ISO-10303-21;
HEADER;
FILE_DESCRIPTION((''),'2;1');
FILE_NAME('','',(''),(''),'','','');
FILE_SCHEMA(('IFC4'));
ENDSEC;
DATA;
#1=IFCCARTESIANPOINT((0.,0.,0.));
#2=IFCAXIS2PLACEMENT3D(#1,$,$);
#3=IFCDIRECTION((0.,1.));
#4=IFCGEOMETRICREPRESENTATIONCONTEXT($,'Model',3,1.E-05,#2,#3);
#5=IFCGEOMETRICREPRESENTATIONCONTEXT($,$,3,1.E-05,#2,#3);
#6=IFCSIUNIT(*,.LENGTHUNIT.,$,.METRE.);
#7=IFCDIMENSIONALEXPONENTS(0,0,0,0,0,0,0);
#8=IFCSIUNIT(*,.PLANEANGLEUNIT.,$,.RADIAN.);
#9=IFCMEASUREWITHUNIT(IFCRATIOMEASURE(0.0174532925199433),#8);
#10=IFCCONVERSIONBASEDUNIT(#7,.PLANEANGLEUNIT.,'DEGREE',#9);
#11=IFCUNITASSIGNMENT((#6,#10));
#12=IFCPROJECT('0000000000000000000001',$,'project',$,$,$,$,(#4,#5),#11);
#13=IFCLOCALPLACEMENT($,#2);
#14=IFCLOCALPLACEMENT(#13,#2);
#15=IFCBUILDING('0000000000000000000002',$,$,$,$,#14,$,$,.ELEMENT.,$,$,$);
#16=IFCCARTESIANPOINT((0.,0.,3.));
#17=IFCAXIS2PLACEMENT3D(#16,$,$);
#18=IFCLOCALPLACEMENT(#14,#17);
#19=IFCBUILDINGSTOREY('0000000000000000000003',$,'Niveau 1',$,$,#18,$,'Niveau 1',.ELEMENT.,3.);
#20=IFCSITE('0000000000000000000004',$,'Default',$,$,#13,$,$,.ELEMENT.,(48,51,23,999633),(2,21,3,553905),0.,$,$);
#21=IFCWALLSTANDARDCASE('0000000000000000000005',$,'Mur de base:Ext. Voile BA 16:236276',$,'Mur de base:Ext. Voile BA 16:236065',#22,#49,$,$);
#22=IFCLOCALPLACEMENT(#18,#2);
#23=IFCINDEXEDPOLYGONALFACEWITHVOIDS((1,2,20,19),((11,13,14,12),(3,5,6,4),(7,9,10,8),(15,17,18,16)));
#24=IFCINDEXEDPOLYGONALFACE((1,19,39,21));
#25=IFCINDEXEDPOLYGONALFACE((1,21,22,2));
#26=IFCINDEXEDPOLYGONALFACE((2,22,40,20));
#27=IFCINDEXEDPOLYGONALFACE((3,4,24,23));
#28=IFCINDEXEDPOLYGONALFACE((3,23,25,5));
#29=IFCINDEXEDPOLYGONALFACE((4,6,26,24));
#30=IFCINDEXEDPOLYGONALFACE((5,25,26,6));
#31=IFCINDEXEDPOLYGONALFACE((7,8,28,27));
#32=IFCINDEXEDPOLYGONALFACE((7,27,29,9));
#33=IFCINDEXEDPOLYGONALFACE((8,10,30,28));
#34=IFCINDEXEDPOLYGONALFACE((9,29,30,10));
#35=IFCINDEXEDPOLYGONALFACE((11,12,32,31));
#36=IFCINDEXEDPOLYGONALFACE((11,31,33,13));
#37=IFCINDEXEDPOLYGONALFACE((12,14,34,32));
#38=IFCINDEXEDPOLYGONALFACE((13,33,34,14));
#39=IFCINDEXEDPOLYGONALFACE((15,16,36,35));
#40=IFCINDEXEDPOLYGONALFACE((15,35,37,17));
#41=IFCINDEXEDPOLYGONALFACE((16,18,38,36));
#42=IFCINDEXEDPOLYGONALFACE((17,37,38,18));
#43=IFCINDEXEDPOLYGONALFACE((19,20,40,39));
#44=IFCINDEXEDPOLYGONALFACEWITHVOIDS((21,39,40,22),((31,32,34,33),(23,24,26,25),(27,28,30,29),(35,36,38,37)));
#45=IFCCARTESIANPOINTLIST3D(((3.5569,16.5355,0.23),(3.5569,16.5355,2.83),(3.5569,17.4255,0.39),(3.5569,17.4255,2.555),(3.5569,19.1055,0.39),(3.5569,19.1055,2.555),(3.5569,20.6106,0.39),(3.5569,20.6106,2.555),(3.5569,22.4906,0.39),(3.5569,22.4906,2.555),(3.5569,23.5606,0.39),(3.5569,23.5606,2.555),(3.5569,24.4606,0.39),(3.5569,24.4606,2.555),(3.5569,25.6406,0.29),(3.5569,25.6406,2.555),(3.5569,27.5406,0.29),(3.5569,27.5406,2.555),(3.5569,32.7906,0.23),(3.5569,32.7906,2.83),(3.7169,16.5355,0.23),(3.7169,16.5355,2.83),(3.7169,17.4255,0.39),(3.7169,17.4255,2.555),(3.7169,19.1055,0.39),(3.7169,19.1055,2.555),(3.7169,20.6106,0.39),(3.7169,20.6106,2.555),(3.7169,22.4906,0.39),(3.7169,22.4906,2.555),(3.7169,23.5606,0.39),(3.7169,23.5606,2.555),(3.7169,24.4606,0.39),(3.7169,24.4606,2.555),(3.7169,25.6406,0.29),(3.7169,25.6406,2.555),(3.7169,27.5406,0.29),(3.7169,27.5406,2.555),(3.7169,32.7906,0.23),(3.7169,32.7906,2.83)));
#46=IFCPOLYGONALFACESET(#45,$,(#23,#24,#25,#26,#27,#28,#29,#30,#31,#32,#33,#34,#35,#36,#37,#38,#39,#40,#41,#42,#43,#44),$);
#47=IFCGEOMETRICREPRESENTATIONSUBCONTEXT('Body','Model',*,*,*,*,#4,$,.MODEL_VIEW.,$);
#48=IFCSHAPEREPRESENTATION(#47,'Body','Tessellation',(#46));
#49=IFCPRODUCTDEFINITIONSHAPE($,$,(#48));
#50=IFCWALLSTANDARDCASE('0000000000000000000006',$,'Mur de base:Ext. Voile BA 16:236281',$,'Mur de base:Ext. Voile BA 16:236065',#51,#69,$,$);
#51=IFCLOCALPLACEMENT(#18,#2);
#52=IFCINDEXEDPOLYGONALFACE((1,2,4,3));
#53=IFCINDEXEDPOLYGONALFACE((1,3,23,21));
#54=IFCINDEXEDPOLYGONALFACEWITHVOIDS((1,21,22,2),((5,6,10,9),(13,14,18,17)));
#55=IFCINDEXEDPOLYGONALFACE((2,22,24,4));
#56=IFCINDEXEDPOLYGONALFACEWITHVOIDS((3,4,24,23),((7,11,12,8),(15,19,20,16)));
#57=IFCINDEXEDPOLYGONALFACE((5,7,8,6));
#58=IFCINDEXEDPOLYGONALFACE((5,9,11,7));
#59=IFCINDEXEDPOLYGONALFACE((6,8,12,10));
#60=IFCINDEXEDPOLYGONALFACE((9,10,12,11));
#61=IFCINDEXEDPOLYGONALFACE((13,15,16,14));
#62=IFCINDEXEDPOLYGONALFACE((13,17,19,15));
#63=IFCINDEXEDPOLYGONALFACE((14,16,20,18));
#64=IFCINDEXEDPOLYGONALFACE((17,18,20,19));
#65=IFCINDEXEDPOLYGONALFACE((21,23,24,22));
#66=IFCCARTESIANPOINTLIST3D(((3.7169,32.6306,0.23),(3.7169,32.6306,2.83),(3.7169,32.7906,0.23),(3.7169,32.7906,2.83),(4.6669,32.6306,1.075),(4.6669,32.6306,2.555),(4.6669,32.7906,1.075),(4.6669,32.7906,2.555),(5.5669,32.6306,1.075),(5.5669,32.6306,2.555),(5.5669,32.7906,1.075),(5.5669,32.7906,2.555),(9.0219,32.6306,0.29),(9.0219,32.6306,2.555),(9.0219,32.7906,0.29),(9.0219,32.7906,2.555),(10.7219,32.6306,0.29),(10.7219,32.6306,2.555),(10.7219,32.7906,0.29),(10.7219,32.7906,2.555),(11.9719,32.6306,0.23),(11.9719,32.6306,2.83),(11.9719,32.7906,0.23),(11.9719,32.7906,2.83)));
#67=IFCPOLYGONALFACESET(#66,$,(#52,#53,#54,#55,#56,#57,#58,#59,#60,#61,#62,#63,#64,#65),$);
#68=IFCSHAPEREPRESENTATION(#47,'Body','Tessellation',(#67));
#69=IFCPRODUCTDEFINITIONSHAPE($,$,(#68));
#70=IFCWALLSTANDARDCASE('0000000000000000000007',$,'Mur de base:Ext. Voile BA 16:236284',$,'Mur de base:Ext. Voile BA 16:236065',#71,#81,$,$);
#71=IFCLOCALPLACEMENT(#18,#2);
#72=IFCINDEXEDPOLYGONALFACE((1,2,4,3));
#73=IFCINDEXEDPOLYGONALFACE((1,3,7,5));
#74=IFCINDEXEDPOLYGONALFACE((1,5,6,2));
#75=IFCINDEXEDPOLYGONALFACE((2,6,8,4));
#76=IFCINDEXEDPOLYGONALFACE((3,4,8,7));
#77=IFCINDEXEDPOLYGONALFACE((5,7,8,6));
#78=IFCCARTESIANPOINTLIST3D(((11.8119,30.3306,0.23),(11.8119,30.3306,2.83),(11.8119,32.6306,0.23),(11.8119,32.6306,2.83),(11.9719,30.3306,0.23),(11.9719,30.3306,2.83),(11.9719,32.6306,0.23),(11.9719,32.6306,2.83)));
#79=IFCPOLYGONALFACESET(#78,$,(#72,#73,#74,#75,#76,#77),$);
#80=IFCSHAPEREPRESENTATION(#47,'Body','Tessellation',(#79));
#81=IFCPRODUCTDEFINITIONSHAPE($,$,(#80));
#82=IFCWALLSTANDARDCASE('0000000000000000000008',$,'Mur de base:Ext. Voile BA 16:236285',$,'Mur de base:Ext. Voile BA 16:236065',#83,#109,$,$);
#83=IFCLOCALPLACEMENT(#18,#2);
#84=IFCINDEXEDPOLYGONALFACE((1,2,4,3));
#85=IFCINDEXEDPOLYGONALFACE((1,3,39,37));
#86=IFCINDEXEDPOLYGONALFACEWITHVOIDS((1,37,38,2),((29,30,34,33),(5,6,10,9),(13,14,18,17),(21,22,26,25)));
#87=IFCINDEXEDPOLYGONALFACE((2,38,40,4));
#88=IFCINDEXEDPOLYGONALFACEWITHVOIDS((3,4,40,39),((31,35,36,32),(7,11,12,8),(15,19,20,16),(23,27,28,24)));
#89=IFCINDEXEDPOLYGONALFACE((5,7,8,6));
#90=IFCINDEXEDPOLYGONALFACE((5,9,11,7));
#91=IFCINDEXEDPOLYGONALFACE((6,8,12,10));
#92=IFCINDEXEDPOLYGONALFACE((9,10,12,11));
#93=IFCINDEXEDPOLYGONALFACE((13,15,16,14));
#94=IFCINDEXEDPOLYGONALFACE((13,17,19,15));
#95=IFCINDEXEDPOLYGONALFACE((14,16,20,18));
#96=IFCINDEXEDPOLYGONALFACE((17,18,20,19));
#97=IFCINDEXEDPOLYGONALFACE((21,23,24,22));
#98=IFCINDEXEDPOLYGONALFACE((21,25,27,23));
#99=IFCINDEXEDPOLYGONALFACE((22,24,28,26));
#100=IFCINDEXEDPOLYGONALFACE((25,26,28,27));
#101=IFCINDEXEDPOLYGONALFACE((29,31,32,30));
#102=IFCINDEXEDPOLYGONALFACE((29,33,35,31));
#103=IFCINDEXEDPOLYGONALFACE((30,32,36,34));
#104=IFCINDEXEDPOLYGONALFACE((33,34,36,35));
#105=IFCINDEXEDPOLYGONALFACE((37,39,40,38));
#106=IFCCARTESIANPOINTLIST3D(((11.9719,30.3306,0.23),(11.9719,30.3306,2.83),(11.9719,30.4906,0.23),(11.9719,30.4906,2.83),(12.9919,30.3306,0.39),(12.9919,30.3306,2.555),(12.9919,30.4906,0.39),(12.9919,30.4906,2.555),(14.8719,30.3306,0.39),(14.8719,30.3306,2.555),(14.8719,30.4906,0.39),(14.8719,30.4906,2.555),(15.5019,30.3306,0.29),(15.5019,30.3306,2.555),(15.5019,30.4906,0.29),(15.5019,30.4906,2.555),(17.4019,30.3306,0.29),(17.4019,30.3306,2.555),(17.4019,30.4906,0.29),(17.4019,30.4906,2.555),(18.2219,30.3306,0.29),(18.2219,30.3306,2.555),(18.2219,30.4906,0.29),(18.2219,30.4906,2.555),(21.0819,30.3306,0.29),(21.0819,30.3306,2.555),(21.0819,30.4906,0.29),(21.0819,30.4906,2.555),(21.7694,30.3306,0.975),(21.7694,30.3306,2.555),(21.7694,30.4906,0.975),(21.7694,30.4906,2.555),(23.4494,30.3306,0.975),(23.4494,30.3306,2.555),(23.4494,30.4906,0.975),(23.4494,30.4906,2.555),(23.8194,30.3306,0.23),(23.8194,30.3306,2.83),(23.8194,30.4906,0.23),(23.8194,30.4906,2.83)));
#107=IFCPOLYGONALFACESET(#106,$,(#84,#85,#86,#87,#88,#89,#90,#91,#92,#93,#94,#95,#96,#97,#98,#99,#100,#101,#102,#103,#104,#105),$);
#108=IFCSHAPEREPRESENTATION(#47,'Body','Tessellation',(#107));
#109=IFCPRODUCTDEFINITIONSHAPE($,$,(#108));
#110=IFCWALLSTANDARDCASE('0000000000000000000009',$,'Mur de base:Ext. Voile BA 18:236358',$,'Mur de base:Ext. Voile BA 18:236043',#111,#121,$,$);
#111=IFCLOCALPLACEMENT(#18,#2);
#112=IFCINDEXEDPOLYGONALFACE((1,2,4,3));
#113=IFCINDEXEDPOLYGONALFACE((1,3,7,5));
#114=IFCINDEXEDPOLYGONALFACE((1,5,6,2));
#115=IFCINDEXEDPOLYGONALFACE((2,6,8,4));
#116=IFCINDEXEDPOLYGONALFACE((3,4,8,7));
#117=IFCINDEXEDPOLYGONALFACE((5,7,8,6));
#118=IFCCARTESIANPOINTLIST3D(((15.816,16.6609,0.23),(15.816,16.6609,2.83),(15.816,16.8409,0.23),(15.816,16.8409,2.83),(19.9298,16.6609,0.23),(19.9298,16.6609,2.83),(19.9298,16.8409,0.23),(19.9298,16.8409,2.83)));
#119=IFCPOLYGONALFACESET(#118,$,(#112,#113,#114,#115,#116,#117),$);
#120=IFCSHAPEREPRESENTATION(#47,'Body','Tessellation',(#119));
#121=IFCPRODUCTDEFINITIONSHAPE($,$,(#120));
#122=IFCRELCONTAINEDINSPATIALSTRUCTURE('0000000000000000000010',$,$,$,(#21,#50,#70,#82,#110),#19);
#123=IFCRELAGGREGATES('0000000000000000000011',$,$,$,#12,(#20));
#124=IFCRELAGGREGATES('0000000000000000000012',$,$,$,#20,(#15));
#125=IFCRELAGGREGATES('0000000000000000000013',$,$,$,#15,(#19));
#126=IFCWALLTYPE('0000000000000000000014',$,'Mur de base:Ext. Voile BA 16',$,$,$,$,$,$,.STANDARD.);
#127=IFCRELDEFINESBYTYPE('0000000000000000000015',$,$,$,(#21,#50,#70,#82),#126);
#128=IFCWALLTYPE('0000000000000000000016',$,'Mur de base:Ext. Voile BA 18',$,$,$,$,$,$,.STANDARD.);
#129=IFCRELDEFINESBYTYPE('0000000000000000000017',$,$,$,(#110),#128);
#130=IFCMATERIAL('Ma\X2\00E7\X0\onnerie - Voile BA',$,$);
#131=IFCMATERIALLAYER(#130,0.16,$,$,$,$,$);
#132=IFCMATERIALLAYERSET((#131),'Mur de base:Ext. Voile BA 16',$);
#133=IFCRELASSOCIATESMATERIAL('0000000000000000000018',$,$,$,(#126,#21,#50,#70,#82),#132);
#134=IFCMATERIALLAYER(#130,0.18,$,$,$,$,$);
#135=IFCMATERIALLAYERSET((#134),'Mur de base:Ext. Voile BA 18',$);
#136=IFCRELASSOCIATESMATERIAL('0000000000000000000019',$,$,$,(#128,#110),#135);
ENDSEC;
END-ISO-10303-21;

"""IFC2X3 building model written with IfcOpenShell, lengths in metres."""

from ifc_helpers import new_model, entity, si_unit, converted_unit, direction, frame, frame_2d, origin, origin_2d_with_axis, place, context, subcontext, project, spatial, rectangle, extrude, material, layer, layer_set, layer_usage, type_object, element, save


model = new_model("IFC2X3")

# Units and contexts
model_context = context("Model", 3, precision=1e-05, world=origin(), true_north=direction((0.0, 1.0)))
context_of_model = context(None, 3, precision=1e-05, world=origin(), true_north=direction((0.0, 1.0)))
body_context = subcontext(model_context, "Body", "Model", "MODEL_VIEW")
ifc_project = project(units=[si_unit("LENGTHUNIT", "METRE"), converted_unit("PLANEANGLEUNIT", "DEGREE", entity("IfcRatioMeasure", 0.0174532925199433), si_unit("PLANEANGLEUNIT", "RADIAN"), dimensions=[0, 0, 0, 0, 0, 0, 0])], contexts=[model_context, context_of_model])

# Site, building, storey
site_placement = place(None, origin())
site = spatial("IfcSite", under=ifc_project, at=site_placement, Name="Default", CompositionType="ELEMENT", RefLatitude=(48, 51, 23, 999633), RefLongitude=(2, 21, 3, 553905), RefElevation=0.0)
building_placement = place(site_placement, origin())
building = spatial("IfcBuilding", under=site, at=building_placement, CompositionType="ELEMENT")
storey_placement = place(building_placement, frame((0.0, 0.0, 3.0)))
storey = spatial("IfcBuildingStorey", under=building, at=storey_placement, Name="Niveau 1", LongName="Niveau 1", CompositionType="ELEMENT", Elevation=3.0)

# Shared definitions
ifc_material = material(Name="Maçonnerie - Voile BA")

# Shared definitions
ifc_layer_1 = layer(ifc_material, 0.16)
ifc_layer_set_1 = layer_set([ifc_layer_1], Name="Mur de base:Ext. Voile BA 16")
wall_type_1 = type_object("IfcWallType", Name="Mur de base:Ext. Voile BA 16", PredefinedType="STANDARD", material=ifc_layer_set_1)

# Walls, openings
ifc_layer_usage_1 = layer_usage(ifc_layer_set_1, "AXIS2", "NEGATIVE", 0.08)
wall_1_placement = place(storey_placement, frame((3.6369, 16.5355, 0.23), z_axis=(0.0, 0.0, 1.0), x_axis=(0.0, 1.0, 0.0)))
wall_1 = element("IfcWallStandardCase", 1, at=wall_1_placement, inside=storey, type_object=wall_type_1, material=ifc_layer_usage_1, Name="Mur de base:Ext. Voile BA 16:236276", ObjectType="Mur de base:Ext. Voile BA 16:236065", context=body_context, shape_type="SweptSolid", body=[
    extrude(rectangle(XDim=16.2552, YDim=0.16, at=frame_2d((8.1276, 0.0), x_axis=(-1.0, 0.0))), origin(), (0.0, 0.0, 1.0), 2.6),
])
opening_1_placement = place(wall_1_placement, origin())
element("IfcOpeningElement", 2, at=opening_1_placement, cuts=wall_1, ObjectType="Opening", context=body_context, shape_type="SweptSolid", body=[
    extrude(rectangle(XDim=2.265, YDim=1.9, at=origin_2d_with_axis()), frame((10.0552, -0.08, 1.1925), z_axis=(0.0, 1.0, 0.0), x_axis=(0.0, 0.0, -1.0)), (0.0, 0.0, 1.0), 0.16),
])
opening_2_placement = place(wall_1_placement, origin())
element("IfcOpeningElement", 3, at=opening_2_placement, cuts=wall_1, ObjectType="Opening", context=body_context, shape_type="SweptSolid", body=[
    extrude(rectangle(XDim=2.165, YDim=0.9, at=frame_2d((0.0, 0.0), x_axis=(1.0, 0.0))), frame((7.4752, -0.08, 1.2425), z_axis=(0.0, 1.0, 0.0), x_axis=(0.0, 0.0, -1.0)), (0.0, 0.0, 1.0), 0.16),
])
opening_3_placement = place(wall_1_placement, origin())
element("IfcOpeningElement", 4, at=opening_3_placement, cuts=wall_1, ObjectType="Opening", context=body_context, shape_type="SweptSolid", body=[
    extrude(rectangle(XDim=2.165, YDim=1.88, at=frame_2d((0.0, 0.0), x_axis=(1.0, 0.0))), frame((5.0152, -0.08, 1.2425), z_axis=(0.0, 1.0, 0.0), x_axis=(0.0, 0.0, -1.0)), (0.0, 0.0, 1.0), 0.16),
])
opening_4_placement = place(wall_1_placement, origin())
element("IfcOpeningElement", 5, at=opening_4_placement, cuts=wall_1, ObjectType="Opening", context=body_context, shape_type="SweptSolid", body=[
    extrude(rectangle(XDim=2.165, YDim=1.68, at=frame_2d((0.0, 0.0), x_axis=(1.0, 0.0))), frame((1.73, -0.08, 1.2425), z_axis=(0.0, 1.0, 0.0), x_axis=(0.0, 0.0, -1.0)), (0.0, 0.0, 1.0), 0.16),
])
ifc_layer_usage_2 = layer_usage(ifc_layer_set_1, "AXIS2", "NEGATIVE", 0.08)
wall_2_placement = place(storey_placement, frame((3.7169, 32.7106, 0.23)))
wall_2 = element("IfcWallStandardCase", 6, at=wall_2_placement, inside=storey, type_object=wall_type_1, material=ifc_layer_usage_2, Name="Mur de base:Ext. Voile BA 16:236281", ObjectType="Mur de base:Ext. Voile BA 16:236065", context=body_context, shape_type="SweptSolid", body=[
    extrude(rectangle(XDim=8.255, YDim=0.16, at=frame_2d((4.1275, 0.0), x_axis=(-1.0, 0.0))), origin(), (0.0, 0.0, 1.0), 2.6),
])
opening_5_placement = place(wall_2_placement, origin())
element("IfcOpeningElement", 7, at=opening_5_placement, cuts=wall_2, ObjectType="Opening", context=body_context, shape_type="SweptSolid", body=[
    extrude(rectangle(XDim=1.48, YDim=0.9, at=origin_2d_with_axis()), frame((1.4, -0.08, 1.585), z_axis=(0.0, 1.0, 0.0), x_axis=(0.0, 0.0, -1.0)), (0.0, 0.0, 1.0), 0.16),
])
opening_6_placement = place(wall_2_placement, origin())
element("IfcOpeningElement", 8, at=opening_6_placement, cuts=wall_2, ObjectType="Opening", context=body_context, shape_type="SweptSolid", body=[
    extrude(rectangle(XDim=2.265, YDim=1.7, at=origin_2d_with_axis()), frame((6.155, -0.08, 1.1925), z_axis=(0.0, 1.0, 0.0), x_axis=(0.0, 0.0, -1.0)), (0.0, 0.0, 1.0), 0.16),
])

# Wall
ifc_layer_usage_3 = layer_usage(ifc_layer_set_1, "AXIS2", "NEGATIVE", 0.08)
wall_3_placement = place(storey_placement, frame((11.8919, 32.6306, 0.23), z_axis=(0.0, 0.0, 1.0), x_axis=(0.0, -1.0, 0.0)))
element("IfcWallStandardCase", 9, at=wall_3_placement, inside=storey, type_object=wall_type_1, material=ifc_layer_usage_3, Name="Mur de base:Ext. Voile BA 16:236284", ObjectType="Mur de base:Ext. Voile BA 16:236065", context=body_context, shape_type="SweptSolid", body=[
    extrude(rectangle(XDim=2.3, YDim=0.16, at=frame_2d((1.15, 0.0), x_axis=(-1.0, 0.0))), origin(), (0.0, 0.0, 1.0), 2.6),
])

# Wall, openings
ifc_layer_usage_4 = layer_usage(ifc_layer_set_1, "AXIS2", "NEGATIVE", 0.08)
wall_4_placement = place(storey_placement, frame((11.9719, 30.4106, 0.23)))
wall_4 = element("IfcWallStandardCase", 10, at=wall_4_placement, inside=storey, type_object=wall_type_1, material=ifc_layer_usage_4, Name="Mur de base:Ext. Voile BA 16:236285", ObjectType="Mur de base:Ext. Voile BA 16:236065", context=body_context, shape_type="SweptSolid", body=[
    extrude(rectangle(XDim=11.8475, YDim=0.16, at=frame_2d((5.9237, 0.0), x_axis=(-1.0, 0.0))), origin(), (0.0, 0.0, 1.0), 2.6),
])
opening_7_placement = place(wall_4_placement, origin())
element("IfcOpeningElement", 11, at=opening_7_placement, cuts=wall_4, ObjectType="Opening", context=body_context, shape_type="SweptSolid", body=[
    extrude(rectangle(XDim=2.165, YDim=1.88, at=frame_2d((0.0, 0.0), x_axis=(1.0, 0.0))), frame((1.96, -0.08, 1.2425), z_axis=(0.0, 1.0, 0.0), x_axis=(0.0, 0.0, -1.0)), (0.0, 0.0, 1.0), 0.16),
])
opening_8_placement = place(wall_4_placement, origin())
element("IfcOpeningElement", 12, at=opening_8_placement, cuts=wall_4, ObjectType="Opening", context=body_context, shape_type="SweptSolid", body=[
    extrude(rectangle(XDim=2.265, YDim=1.9, at=origin_2d_with_axis()), frame((4.48, -0.08, 1.1925), z_axis=(0.0, 1.0, 0.0), x_axis=(0.0, 0.0, -1.0)), (0.0, 0.0, 1.0), 0.16),
])
opening_9_placement = place(wall_4_placement, origin())
element("IfcOpeningElement", 13, at=opening_9_placement, cuts=wall_4, ObjectType="Opening", context=body_context, shape_type="SweptSolid", body=[
    extrude(rectangle(XDim=2.265, YDim=2.86, at=frame_2d((0.0, 0.0), x_axis=(1.0, 0.0))), frame((7.68, -0.08, 1.1925), z_axis=(0.0, 1.0, 0.0), x_axis=(0.0, 0.0, -1.0)), (0.0, 0.0, 1.0), 0.16),
])
opening_10_placement = place(wall_4_placement, origin())
element("IfcOpeningElement", 14, at=opening_10_placement, cuts=wall_4, ObjectType="Opening", context=body_context, shape_type="SweptSolid", body=[
    extrude(rectangle(XDim=1.58, YDim=1.68, at=origin_2d_with_axis()), frame((10.6375, -0.08, 1.535), z_axis=(0.0, 1.0, 0.0), x_axis=(0.0, 0.0, -1.0)), (0.0, 0.0, 1.0), 0.16),
])

# Wall
ifc_layer_2 = layer(ifc_material, 0.18)
ifc_layer_set_2 = layer_set([ifc_layer_2], Name="Mur de base:Ext. Voile BA 18")
ifc_layer_usage_5 = layer_usage(ifc_layer_set_2, "AXIS2", "NEGATIVE", 0.09)
wall_type_2 = type_object("IfcWallType", Name="Mur de base:Ext. Voile BA 18", PredefinedType="STANDARD", material=ifc_layer_set_2)
wall_5_placement = place(storey_placement, frame((15.816, 16.7509, 0.23)))
element("IfcWallStandardCase", 15, at=wall_5_placement, inside=storey, type_object=wall_type_2, material=ifc_layer_usage_5, Name="Mur de base:Ext. Voile BA 18:236358", ObjectType="Mur de base:Ext. Voile BA 18:236043", context=body_context, shape_type="SweptSolid", body=[
    extrude(rectangle(XDim=4.1139, YDim=0.18, at=frame_2d((2.0569, 0.0), x_axis=(-1.0, 0.0))), origin(), (0.0, 0.0, 1.0), 2.6),
])

save(model, "model.ifc")
